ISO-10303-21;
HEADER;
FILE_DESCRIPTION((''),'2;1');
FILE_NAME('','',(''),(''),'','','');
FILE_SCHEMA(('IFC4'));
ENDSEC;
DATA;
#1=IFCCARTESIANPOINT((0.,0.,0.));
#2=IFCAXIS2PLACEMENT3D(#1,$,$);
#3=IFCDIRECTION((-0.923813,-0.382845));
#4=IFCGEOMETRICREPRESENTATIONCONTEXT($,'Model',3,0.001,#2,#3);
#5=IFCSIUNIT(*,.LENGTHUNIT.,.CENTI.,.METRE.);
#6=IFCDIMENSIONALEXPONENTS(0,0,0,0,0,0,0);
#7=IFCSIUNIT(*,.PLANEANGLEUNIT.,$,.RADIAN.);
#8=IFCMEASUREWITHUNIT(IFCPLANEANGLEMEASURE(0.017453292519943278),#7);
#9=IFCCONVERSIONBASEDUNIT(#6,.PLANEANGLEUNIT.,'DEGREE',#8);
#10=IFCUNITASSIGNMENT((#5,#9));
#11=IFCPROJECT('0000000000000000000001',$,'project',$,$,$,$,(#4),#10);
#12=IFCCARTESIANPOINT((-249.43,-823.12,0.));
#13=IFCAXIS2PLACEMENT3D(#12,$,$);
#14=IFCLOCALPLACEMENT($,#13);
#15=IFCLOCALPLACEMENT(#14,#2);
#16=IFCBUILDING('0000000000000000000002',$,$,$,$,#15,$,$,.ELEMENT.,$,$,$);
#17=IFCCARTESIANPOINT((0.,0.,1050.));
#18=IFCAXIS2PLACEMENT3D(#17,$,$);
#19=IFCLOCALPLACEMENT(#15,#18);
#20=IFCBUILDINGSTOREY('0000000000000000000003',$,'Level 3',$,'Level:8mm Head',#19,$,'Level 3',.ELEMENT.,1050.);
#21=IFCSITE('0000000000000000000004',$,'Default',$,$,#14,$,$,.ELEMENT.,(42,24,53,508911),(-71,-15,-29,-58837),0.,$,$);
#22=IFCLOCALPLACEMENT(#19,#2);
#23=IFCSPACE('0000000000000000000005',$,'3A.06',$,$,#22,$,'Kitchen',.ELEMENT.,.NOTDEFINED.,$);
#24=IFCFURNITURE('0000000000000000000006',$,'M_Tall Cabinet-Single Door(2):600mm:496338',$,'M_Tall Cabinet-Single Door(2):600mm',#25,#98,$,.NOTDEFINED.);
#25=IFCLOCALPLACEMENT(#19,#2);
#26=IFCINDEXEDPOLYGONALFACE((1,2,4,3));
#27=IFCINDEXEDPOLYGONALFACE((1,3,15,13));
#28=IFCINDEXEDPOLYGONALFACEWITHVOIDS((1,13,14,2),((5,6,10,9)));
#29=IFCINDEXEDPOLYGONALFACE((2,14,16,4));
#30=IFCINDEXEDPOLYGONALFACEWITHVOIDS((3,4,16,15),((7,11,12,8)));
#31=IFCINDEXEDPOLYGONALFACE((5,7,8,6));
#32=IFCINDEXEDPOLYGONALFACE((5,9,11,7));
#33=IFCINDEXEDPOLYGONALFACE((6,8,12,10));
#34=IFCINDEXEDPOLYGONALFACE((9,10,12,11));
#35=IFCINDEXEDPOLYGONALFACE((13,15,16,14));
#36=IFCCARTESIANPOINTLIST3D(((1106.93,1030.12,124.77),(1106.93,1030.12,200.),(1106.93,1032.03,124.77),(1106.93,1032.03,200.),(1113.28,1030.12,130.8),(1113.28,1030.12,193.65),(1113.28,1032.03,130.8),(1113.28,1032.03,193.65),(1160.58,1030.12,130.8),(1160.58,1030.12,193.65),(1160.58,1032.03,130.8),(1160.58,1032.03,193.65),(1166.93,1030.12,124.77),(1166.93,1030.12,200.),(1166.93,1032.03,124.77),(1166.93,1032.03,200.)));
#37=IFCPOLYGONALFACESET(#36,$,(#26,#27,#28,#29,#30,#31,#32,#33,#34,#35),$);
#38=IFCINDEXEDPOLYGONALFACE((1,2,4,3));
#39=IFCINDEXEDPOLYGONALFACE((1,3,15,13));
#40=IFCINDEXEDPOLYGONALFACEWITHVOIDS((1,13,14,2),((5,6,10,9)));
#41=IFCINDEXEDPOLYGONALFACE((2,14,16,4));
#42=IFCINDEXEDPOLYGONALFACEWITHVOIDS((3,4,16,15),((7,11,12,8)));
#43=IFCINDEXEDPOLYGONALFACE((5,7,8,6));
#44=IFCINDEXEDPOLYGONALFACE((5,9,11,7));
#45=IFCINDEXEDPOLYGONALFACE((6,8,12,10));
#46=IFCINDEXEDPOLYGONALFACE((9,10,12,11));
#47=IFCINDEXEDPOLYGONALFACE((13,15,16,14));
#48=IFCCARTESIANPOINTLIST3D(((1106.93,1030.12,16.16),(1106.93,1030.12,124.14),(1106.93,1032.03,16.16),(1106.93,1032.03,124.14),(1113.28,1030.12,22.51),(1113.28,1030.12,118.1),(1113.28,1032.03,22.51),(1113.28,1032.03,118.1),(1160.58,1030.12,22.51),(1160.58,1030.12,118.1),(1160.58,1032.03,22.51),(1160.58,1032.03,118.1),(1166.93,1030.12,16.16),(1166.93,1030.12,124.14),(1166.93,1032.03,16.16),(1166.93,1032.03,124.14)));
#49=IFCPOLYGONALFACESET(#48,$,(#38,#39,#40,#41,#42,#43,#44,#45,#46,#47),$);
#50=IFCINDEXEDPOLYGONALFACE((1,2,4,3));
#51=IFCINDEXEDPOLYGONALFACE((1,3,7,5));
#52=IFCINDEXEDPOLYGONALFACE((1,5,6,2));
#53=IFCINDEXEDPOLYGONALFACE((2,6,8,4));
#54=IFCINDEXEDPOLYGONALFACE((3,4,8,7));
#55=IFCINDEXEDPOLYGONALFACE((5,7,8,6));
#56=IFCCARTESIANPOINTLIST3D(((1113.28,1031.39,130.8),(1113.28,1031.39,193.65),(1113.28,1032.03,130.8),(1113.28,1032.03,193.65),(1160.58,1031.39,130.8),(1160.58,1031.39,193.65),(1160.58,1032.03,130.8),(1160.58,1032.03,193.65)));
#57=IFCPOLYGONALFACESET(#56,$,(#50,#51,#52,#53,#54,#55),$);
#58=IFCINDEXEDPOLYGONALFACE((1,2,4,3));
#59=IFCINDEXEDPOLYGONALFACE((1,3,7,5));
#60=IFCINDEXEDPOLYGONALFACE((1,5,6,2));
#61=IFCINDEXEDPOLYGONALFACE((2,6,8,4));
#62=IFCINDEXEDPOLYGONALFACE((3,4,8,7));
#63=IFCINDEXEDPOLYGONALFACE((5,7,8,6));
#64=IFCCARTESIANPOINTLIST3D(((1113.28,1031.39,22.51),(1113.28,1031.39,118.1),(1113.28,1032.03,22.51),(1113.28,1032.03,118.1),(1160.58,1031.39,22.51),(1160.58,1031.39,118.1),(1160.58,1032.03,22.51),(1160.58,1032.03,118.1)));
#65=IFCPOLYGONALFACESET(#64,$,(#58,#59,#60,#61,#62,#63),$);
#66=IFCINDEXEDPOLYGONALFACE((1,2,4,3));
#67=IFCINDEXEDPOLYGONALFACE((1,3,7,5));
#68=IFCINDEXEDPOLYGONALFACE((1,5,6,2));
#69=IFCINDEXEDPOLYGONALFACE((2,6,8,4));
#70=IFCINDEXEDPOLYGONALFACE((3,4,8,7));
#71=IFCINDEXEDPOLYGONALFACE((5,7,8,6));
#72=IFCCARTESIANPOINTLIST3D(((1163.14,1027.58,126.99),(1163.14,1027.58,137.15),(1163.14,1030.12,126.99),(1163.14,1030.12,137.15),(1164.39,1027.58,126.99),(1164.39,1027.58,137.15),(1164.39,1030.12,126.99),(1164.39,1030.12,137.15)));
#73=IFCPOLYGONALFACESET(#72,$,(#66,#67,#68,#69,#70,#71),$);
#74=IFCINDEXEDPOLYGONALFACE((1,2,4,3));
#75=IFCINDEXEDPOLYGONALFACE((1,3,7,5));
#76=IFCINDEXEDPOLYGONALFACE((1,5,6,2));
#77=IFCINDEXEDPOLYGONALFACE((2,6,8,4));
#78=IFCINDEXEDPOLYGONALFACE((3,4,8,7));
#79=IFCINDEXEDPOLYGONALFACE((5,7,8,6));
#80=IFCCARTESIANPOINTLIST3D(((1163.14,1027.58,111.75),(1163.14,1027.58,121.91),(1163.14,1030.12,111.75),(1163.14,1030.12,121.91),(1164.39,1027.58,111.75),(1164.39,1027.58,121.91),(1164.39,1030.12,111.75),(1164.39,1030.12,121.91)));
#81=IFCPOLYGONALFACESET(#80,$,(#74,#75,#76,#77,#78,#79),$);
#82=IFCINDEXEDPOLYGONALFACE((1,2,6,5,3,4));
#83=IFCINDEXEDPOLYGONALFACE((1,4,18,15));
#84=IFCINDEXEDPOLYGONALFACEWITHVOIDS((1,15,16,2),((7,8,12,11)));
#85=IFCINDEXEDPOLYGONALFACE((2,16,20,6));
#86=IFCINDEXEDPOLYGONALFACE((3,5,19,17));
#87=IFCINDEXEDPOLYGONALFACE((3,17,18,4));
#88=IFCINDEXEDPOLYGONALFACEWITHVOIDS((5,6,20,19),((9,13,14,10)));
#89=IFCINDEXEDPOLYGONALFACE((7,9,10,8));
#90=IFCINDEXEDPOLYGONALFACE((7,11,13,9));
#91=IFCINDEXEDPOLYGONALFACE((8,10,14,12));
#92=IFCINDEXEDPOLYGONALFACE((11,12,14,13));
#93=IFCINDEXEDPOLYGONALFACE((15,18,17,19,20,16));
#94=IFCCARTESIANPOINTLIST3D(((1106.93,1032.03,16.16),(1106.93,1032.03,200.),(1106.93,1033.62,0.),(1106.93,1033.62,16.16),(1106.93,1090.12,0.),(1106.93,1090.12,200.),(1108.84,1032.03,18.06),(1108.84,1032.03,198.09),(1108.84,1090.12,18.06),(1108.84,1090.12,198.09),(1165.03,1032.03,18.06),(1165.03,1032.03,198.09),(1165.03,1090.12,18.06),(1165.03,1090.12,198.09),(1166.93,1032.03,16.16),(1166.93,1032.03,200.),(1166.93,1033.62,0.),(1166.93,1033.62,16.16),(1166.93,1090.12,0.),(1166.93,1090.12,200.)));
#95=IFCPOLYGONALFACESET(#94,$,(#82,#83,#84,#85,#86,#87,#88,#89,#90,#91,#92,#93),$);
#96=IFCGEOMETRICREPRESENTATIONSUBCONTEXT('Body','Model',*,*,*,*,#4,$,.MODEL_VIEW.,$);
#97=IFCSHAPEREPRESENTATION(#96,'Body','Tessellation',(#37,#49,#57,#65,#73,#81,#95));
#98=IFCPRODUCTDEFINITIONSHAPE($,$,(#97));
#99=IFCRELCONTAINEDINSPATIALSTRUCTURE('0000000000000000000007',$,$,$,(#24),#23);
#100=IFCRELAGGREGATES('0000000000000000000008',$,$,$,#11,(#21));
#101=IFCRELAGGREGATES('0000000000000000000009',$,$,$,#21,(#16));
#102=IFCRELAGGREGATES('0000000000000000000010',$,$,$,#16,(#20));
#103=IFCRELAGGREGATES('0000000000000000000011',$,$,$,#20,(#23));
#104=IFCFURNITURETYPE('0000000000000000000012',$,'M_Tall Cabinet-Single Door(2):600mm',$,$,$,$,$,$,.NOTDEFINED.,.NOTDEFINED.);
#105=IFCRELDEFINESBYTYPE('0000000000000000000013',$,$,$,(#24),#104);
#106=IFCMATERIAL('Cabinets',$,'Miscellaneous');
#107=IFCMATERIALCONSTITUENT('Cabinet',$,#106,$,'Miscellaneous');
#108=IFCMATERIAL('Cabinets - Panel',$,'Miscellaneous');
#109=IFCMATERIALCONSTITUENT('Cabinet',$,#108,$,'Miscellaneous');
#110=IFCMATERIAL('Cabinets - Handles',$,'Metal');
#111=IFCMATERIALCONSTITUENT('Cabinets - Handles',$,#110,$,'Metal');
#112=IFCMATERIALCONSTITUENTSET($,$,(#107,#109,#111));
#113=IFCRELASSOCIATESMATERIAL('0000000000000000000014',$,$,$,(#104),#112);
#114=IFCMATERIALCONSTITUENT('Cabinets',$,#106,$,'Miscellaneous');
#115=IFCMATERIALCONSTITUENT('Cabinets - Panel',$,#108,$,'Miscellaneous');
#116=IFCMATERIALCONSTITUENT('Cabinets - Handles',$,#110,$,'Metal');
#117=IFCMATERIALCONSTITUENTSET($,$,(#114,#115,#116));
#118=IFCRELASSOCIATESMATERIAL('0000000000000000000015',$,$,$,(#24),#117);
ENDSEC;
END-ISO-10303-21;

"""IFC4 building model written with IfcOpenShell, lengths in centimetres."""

from ifc_helpers import new_model, entity, si_unit, converted_unit, direction, frame, origin, place, context, subcontext, project, spatial, indexed_curve, outline, extrude, source, transform, mapped, material, constituent, constituent_set, type_object, type_shapes, element, save


model = new_model("IFC4")

# Units and contexts
model_context = context("Model", 3, precision=0.001, world=origin(), true_north=direction((-0.923813, -0.382845)))
body_context = subcontext(model_context, "Body", "Model", "MODEL_VIEW")
ifc_project = project(units=[si_unit("LENGTHUNIT", "METRE", prefix="CENTI"), converted_unit("PLANEANGLEUNIT", "DEGREE", entity("IfcPlaneAngleMeasure", 0.017453292519943278), si_unit("PLANEANGLEUNIT", "RADIAN"), dimensions=[0, 0, 0, 0, 0, 0, 0])], contexts=[model_context])

# Site, building, storey
site_placement = place(None, frame((-249.43, -823.12, 0.0)))
site = spatial("IfcSite", under=ifc_project, at=site_placement, Name="Default", CompositionType="ELEMENT", RefLatitude=(42, 24, 53, 508911), RefLongitude=(-71, -15, -29, -58837), RefElevation=0.0)
building_placement = place(site_placement, origin())
building = spatial("IfcBuilding", under=site, at=building_placement, CompositionType="ELEMENT")
storey_placement = place(building_placement, frame((0.0, 0.0, 1050.0)))
storey = spatial("IfcBuildingStorey", under=building, at=storey_placement, Name="Level 3", ObjectType="Level:8mm Head", LongName="Level 3", CompositionType="ELEMENT", Elevation=1050.0)

# Shared definitions
space_1_placement = place(storey_placement, origin())
space_1 = spatial("IfcSpace", under=storey, at=space_1_placement, Name="3A.06", LongName="Kitchen", CompositionType="ELEMENT", PredefinedType="NOTDEFINED")

# Furniture, opening
ifc_material_1 = material(Name="Cabinets", Category="Miscellaneous")
ifc_material_2 = material(Name="Cabinets - Panel", Category="Miscellaneous")
ifc_material_3 = material(Name="Cabinets - Handles", Category="Metal")
ifc_constituent_1 = constituent(ifc_material_1, Name="Cabinets", Category="Miscellaneous")
ifc_constituent_2 = constituent(ifc_material_2, Name="Cabinets - Panel", Category="Miscellaneous")
ifc_constituent_3 = constituent(ifc_material_3, Name="Cabinets - Handles", Category="Metal")
ifc_constituent_set_1 = constituent_set(constituents=[ifc_constituent_1, ifc_constituent_2, ifc_constituent_3])
ifc_constituent_4 = constituent(ifc_material_1, Name="Cabinet", Category="Miscellaneous")
ifc_constituent_5 = constituent(ifc_material_2, Name="Cabinet", Category="Miscellaneous")
ifc_constituent_6 = constituent(ifc_material_3, Name="Cabinets - Handles", Category="Metal")
ifc_constituent_set_2 = constituent_set(constituents=[ifc_constituent_4, ifc_constituent_5, ifc_constituent_6])
furniture_type_1 = type_object("IfcFurnitureType", Name="M_Tall Cabinet-Single Door(2):600mm", AssemblyPlace="NOTDEFINED", PredefinedType="NOTDEFINED", material=ifc_constituent_set_2)
shared_shape_1 = source(origin(), body_context, "Body", "SweptSolid", [
    extrude(outline(indexed_curve([(-0.95, -28.09), (0.95, -28.09), (0.95, 28.09), (-0.95, 28.09), (-0.95, -28.09)], self_intersect=False)), frame((1.87, -0.95, 18.06), z_axis=(0.0, 0.0, 1.0), x_axis=(0.0, 1.0, 0.0)), (0.0, 0.0, 1.0), 180.03),
    extrude(outline(indexed_curve([(-37.61, -30.0), (37.61, -30.0), (37.61, 30.0), (-37.61, 30.0), (-37.61, -30.0)], self_intersect=False), holes=[indexed_curve([(-31.26, -23.65), (-31.26, 23.65), (31.58, 23.65), (31.58, -23.65), (-31.26, -23.65)], self_intersect=False)]), frame((1.87, -60.0, 162.39), z_axis=(0.0, 1.0, 0.0), x_axis=(0.0, 0.0, -1.0)), (0.0, 0.0, 1.0), 1.91),
    extrude(outline(indexed_curve([(-30.0, -53.99), (30.0, -53.99), (30.0, 53.99), (-30.0, 53.99), (-30.0, -53.99)], self_intersect=False), holes=[indexed_curve([(-23.65, 47.96), (23.65, 47.96), (23.65, -47.64), (-23.65, -47.64), (-23.65, 47.96)], self_intersect=False)]), frame((1.87, -60.0, 70.15), z_axis=(0.0, 1.0, 0.0), x_axis=(-1.0, 0.0, 0.0)), (0.0, 0.0, 1.0), 1.91),
    extrude(outline(indexed_curve([(-0.32, -23.65), (0.32, -23.65), (0.32, 23.65), (-0.32, 23.65), (-0.32, -23.65)], self_intersect=False)), frame((1.87, -58.41, 130.8), z_axis=(0.0, 0.0, 1.0), x_axis=(0.0, 1.0, 0.0)), (0.0, 0.0, 1.0), 62.85),
    extrude(outline(indexed_curve([(-0.32, -23.65), (0.32, -23.65), (0.32, 23.65), (-0.32, 23.65), (-0.32, -23.65)], self_intersect=False)), frame((1.87, -58.41, 22.51), z_axis=(0.0, 0.0, 1.0), x_axis=(0.0, 1.0, 0.0)), (0.0, 0.0, 1.0), 95.6),
    extrude(outline(indexed_curve([(-1.27, -0.63), (1.27, -0.63), (1.27, 0.63), (-1.27, 0.63), (-1.27, -0.63)], self_intersect=False)), frame((28.71, -61.27, 126.99), z_axis=(0.0, 0.0, 1.0), x_axis=(0.0, 1.0, 0.0)), (0.0, 0.0, 1.0), 10.16),
    extrude(outline(indexed_curve([(-1.27, -0.63), (1.27, -0.63), (1.27, 0.63), (-1.27, 0.63), (-1.27, -0.63)], self_intersect=False)), frame((28.71, -61.27, 111.75), z_axis=(0.0, 0.0, 1.0), x_axis=(0.0, 1.0, 0.0)), (0.0, 0.0, 1.0), 10.16),
    extrude(outline(indexed_curve([(-19.9, 55.89), (-19.9, -127.95), (38.2, -127.95), (38.2, 72.05), (-18.3, 72.05), (-18.3, 55.89), (-19.9, 55.89)], self_intersect=False)), frame((-28.13, -38.2, 72.05), z_axis=(-1.0, 0.0, 0.0), x_axis=(0.0, 1.0, 0.0)), (0.0, 0.0, -1.0), 60.0),
])
type_shapes(furniture_type_1, [shared_shape_1])
furniture_1_placement = place(space_1_placement, frame((1135.06, 1090.12, 0.0)))
furniture_1 = element("IfcFurniture", 1, at=furniture_1_placement, inside=space_1, type_object=furniture_type_1, material=ifc_constituent_set_1, Name="M_Tall Cabinet-Single Door(2):600mm:496338", ObjectType="M_Tall Cabinet-Single Door(2):600mm", PredefinedType="NOTDEFINED", context=body_context, shape_type="MappedRepresentation", body=[
    mapped(shared_shape_1, transform((0.0, 0.0, 0.0), scale=1.0)),
])
opening_1_placement = place(storey_placement, frame((1135.06, 1090.12, 1050.0)))
element("IfcOpeningElement", 2, at=opening_1_placement, cuts=furniture_1, PredefinedType="OPENING", context=body_context, shape_type="SweptSolid", body=[
    extrude(outline(indexed_curve([(-90.02, -28.09), (90.02, -28.09), (90.02, 28.09), (-90.02, 28.09), (-90.02, -28.09)], self_intersect=False)), frame((1.87, -58.09, -941.92), z_axis=(0.0, 1.0, 0.0), x_axis=(0.0, 0.0, -1.0)), (0.0, 0.0, 1.0), 58.09),
])

save(model, "model.ifc")
